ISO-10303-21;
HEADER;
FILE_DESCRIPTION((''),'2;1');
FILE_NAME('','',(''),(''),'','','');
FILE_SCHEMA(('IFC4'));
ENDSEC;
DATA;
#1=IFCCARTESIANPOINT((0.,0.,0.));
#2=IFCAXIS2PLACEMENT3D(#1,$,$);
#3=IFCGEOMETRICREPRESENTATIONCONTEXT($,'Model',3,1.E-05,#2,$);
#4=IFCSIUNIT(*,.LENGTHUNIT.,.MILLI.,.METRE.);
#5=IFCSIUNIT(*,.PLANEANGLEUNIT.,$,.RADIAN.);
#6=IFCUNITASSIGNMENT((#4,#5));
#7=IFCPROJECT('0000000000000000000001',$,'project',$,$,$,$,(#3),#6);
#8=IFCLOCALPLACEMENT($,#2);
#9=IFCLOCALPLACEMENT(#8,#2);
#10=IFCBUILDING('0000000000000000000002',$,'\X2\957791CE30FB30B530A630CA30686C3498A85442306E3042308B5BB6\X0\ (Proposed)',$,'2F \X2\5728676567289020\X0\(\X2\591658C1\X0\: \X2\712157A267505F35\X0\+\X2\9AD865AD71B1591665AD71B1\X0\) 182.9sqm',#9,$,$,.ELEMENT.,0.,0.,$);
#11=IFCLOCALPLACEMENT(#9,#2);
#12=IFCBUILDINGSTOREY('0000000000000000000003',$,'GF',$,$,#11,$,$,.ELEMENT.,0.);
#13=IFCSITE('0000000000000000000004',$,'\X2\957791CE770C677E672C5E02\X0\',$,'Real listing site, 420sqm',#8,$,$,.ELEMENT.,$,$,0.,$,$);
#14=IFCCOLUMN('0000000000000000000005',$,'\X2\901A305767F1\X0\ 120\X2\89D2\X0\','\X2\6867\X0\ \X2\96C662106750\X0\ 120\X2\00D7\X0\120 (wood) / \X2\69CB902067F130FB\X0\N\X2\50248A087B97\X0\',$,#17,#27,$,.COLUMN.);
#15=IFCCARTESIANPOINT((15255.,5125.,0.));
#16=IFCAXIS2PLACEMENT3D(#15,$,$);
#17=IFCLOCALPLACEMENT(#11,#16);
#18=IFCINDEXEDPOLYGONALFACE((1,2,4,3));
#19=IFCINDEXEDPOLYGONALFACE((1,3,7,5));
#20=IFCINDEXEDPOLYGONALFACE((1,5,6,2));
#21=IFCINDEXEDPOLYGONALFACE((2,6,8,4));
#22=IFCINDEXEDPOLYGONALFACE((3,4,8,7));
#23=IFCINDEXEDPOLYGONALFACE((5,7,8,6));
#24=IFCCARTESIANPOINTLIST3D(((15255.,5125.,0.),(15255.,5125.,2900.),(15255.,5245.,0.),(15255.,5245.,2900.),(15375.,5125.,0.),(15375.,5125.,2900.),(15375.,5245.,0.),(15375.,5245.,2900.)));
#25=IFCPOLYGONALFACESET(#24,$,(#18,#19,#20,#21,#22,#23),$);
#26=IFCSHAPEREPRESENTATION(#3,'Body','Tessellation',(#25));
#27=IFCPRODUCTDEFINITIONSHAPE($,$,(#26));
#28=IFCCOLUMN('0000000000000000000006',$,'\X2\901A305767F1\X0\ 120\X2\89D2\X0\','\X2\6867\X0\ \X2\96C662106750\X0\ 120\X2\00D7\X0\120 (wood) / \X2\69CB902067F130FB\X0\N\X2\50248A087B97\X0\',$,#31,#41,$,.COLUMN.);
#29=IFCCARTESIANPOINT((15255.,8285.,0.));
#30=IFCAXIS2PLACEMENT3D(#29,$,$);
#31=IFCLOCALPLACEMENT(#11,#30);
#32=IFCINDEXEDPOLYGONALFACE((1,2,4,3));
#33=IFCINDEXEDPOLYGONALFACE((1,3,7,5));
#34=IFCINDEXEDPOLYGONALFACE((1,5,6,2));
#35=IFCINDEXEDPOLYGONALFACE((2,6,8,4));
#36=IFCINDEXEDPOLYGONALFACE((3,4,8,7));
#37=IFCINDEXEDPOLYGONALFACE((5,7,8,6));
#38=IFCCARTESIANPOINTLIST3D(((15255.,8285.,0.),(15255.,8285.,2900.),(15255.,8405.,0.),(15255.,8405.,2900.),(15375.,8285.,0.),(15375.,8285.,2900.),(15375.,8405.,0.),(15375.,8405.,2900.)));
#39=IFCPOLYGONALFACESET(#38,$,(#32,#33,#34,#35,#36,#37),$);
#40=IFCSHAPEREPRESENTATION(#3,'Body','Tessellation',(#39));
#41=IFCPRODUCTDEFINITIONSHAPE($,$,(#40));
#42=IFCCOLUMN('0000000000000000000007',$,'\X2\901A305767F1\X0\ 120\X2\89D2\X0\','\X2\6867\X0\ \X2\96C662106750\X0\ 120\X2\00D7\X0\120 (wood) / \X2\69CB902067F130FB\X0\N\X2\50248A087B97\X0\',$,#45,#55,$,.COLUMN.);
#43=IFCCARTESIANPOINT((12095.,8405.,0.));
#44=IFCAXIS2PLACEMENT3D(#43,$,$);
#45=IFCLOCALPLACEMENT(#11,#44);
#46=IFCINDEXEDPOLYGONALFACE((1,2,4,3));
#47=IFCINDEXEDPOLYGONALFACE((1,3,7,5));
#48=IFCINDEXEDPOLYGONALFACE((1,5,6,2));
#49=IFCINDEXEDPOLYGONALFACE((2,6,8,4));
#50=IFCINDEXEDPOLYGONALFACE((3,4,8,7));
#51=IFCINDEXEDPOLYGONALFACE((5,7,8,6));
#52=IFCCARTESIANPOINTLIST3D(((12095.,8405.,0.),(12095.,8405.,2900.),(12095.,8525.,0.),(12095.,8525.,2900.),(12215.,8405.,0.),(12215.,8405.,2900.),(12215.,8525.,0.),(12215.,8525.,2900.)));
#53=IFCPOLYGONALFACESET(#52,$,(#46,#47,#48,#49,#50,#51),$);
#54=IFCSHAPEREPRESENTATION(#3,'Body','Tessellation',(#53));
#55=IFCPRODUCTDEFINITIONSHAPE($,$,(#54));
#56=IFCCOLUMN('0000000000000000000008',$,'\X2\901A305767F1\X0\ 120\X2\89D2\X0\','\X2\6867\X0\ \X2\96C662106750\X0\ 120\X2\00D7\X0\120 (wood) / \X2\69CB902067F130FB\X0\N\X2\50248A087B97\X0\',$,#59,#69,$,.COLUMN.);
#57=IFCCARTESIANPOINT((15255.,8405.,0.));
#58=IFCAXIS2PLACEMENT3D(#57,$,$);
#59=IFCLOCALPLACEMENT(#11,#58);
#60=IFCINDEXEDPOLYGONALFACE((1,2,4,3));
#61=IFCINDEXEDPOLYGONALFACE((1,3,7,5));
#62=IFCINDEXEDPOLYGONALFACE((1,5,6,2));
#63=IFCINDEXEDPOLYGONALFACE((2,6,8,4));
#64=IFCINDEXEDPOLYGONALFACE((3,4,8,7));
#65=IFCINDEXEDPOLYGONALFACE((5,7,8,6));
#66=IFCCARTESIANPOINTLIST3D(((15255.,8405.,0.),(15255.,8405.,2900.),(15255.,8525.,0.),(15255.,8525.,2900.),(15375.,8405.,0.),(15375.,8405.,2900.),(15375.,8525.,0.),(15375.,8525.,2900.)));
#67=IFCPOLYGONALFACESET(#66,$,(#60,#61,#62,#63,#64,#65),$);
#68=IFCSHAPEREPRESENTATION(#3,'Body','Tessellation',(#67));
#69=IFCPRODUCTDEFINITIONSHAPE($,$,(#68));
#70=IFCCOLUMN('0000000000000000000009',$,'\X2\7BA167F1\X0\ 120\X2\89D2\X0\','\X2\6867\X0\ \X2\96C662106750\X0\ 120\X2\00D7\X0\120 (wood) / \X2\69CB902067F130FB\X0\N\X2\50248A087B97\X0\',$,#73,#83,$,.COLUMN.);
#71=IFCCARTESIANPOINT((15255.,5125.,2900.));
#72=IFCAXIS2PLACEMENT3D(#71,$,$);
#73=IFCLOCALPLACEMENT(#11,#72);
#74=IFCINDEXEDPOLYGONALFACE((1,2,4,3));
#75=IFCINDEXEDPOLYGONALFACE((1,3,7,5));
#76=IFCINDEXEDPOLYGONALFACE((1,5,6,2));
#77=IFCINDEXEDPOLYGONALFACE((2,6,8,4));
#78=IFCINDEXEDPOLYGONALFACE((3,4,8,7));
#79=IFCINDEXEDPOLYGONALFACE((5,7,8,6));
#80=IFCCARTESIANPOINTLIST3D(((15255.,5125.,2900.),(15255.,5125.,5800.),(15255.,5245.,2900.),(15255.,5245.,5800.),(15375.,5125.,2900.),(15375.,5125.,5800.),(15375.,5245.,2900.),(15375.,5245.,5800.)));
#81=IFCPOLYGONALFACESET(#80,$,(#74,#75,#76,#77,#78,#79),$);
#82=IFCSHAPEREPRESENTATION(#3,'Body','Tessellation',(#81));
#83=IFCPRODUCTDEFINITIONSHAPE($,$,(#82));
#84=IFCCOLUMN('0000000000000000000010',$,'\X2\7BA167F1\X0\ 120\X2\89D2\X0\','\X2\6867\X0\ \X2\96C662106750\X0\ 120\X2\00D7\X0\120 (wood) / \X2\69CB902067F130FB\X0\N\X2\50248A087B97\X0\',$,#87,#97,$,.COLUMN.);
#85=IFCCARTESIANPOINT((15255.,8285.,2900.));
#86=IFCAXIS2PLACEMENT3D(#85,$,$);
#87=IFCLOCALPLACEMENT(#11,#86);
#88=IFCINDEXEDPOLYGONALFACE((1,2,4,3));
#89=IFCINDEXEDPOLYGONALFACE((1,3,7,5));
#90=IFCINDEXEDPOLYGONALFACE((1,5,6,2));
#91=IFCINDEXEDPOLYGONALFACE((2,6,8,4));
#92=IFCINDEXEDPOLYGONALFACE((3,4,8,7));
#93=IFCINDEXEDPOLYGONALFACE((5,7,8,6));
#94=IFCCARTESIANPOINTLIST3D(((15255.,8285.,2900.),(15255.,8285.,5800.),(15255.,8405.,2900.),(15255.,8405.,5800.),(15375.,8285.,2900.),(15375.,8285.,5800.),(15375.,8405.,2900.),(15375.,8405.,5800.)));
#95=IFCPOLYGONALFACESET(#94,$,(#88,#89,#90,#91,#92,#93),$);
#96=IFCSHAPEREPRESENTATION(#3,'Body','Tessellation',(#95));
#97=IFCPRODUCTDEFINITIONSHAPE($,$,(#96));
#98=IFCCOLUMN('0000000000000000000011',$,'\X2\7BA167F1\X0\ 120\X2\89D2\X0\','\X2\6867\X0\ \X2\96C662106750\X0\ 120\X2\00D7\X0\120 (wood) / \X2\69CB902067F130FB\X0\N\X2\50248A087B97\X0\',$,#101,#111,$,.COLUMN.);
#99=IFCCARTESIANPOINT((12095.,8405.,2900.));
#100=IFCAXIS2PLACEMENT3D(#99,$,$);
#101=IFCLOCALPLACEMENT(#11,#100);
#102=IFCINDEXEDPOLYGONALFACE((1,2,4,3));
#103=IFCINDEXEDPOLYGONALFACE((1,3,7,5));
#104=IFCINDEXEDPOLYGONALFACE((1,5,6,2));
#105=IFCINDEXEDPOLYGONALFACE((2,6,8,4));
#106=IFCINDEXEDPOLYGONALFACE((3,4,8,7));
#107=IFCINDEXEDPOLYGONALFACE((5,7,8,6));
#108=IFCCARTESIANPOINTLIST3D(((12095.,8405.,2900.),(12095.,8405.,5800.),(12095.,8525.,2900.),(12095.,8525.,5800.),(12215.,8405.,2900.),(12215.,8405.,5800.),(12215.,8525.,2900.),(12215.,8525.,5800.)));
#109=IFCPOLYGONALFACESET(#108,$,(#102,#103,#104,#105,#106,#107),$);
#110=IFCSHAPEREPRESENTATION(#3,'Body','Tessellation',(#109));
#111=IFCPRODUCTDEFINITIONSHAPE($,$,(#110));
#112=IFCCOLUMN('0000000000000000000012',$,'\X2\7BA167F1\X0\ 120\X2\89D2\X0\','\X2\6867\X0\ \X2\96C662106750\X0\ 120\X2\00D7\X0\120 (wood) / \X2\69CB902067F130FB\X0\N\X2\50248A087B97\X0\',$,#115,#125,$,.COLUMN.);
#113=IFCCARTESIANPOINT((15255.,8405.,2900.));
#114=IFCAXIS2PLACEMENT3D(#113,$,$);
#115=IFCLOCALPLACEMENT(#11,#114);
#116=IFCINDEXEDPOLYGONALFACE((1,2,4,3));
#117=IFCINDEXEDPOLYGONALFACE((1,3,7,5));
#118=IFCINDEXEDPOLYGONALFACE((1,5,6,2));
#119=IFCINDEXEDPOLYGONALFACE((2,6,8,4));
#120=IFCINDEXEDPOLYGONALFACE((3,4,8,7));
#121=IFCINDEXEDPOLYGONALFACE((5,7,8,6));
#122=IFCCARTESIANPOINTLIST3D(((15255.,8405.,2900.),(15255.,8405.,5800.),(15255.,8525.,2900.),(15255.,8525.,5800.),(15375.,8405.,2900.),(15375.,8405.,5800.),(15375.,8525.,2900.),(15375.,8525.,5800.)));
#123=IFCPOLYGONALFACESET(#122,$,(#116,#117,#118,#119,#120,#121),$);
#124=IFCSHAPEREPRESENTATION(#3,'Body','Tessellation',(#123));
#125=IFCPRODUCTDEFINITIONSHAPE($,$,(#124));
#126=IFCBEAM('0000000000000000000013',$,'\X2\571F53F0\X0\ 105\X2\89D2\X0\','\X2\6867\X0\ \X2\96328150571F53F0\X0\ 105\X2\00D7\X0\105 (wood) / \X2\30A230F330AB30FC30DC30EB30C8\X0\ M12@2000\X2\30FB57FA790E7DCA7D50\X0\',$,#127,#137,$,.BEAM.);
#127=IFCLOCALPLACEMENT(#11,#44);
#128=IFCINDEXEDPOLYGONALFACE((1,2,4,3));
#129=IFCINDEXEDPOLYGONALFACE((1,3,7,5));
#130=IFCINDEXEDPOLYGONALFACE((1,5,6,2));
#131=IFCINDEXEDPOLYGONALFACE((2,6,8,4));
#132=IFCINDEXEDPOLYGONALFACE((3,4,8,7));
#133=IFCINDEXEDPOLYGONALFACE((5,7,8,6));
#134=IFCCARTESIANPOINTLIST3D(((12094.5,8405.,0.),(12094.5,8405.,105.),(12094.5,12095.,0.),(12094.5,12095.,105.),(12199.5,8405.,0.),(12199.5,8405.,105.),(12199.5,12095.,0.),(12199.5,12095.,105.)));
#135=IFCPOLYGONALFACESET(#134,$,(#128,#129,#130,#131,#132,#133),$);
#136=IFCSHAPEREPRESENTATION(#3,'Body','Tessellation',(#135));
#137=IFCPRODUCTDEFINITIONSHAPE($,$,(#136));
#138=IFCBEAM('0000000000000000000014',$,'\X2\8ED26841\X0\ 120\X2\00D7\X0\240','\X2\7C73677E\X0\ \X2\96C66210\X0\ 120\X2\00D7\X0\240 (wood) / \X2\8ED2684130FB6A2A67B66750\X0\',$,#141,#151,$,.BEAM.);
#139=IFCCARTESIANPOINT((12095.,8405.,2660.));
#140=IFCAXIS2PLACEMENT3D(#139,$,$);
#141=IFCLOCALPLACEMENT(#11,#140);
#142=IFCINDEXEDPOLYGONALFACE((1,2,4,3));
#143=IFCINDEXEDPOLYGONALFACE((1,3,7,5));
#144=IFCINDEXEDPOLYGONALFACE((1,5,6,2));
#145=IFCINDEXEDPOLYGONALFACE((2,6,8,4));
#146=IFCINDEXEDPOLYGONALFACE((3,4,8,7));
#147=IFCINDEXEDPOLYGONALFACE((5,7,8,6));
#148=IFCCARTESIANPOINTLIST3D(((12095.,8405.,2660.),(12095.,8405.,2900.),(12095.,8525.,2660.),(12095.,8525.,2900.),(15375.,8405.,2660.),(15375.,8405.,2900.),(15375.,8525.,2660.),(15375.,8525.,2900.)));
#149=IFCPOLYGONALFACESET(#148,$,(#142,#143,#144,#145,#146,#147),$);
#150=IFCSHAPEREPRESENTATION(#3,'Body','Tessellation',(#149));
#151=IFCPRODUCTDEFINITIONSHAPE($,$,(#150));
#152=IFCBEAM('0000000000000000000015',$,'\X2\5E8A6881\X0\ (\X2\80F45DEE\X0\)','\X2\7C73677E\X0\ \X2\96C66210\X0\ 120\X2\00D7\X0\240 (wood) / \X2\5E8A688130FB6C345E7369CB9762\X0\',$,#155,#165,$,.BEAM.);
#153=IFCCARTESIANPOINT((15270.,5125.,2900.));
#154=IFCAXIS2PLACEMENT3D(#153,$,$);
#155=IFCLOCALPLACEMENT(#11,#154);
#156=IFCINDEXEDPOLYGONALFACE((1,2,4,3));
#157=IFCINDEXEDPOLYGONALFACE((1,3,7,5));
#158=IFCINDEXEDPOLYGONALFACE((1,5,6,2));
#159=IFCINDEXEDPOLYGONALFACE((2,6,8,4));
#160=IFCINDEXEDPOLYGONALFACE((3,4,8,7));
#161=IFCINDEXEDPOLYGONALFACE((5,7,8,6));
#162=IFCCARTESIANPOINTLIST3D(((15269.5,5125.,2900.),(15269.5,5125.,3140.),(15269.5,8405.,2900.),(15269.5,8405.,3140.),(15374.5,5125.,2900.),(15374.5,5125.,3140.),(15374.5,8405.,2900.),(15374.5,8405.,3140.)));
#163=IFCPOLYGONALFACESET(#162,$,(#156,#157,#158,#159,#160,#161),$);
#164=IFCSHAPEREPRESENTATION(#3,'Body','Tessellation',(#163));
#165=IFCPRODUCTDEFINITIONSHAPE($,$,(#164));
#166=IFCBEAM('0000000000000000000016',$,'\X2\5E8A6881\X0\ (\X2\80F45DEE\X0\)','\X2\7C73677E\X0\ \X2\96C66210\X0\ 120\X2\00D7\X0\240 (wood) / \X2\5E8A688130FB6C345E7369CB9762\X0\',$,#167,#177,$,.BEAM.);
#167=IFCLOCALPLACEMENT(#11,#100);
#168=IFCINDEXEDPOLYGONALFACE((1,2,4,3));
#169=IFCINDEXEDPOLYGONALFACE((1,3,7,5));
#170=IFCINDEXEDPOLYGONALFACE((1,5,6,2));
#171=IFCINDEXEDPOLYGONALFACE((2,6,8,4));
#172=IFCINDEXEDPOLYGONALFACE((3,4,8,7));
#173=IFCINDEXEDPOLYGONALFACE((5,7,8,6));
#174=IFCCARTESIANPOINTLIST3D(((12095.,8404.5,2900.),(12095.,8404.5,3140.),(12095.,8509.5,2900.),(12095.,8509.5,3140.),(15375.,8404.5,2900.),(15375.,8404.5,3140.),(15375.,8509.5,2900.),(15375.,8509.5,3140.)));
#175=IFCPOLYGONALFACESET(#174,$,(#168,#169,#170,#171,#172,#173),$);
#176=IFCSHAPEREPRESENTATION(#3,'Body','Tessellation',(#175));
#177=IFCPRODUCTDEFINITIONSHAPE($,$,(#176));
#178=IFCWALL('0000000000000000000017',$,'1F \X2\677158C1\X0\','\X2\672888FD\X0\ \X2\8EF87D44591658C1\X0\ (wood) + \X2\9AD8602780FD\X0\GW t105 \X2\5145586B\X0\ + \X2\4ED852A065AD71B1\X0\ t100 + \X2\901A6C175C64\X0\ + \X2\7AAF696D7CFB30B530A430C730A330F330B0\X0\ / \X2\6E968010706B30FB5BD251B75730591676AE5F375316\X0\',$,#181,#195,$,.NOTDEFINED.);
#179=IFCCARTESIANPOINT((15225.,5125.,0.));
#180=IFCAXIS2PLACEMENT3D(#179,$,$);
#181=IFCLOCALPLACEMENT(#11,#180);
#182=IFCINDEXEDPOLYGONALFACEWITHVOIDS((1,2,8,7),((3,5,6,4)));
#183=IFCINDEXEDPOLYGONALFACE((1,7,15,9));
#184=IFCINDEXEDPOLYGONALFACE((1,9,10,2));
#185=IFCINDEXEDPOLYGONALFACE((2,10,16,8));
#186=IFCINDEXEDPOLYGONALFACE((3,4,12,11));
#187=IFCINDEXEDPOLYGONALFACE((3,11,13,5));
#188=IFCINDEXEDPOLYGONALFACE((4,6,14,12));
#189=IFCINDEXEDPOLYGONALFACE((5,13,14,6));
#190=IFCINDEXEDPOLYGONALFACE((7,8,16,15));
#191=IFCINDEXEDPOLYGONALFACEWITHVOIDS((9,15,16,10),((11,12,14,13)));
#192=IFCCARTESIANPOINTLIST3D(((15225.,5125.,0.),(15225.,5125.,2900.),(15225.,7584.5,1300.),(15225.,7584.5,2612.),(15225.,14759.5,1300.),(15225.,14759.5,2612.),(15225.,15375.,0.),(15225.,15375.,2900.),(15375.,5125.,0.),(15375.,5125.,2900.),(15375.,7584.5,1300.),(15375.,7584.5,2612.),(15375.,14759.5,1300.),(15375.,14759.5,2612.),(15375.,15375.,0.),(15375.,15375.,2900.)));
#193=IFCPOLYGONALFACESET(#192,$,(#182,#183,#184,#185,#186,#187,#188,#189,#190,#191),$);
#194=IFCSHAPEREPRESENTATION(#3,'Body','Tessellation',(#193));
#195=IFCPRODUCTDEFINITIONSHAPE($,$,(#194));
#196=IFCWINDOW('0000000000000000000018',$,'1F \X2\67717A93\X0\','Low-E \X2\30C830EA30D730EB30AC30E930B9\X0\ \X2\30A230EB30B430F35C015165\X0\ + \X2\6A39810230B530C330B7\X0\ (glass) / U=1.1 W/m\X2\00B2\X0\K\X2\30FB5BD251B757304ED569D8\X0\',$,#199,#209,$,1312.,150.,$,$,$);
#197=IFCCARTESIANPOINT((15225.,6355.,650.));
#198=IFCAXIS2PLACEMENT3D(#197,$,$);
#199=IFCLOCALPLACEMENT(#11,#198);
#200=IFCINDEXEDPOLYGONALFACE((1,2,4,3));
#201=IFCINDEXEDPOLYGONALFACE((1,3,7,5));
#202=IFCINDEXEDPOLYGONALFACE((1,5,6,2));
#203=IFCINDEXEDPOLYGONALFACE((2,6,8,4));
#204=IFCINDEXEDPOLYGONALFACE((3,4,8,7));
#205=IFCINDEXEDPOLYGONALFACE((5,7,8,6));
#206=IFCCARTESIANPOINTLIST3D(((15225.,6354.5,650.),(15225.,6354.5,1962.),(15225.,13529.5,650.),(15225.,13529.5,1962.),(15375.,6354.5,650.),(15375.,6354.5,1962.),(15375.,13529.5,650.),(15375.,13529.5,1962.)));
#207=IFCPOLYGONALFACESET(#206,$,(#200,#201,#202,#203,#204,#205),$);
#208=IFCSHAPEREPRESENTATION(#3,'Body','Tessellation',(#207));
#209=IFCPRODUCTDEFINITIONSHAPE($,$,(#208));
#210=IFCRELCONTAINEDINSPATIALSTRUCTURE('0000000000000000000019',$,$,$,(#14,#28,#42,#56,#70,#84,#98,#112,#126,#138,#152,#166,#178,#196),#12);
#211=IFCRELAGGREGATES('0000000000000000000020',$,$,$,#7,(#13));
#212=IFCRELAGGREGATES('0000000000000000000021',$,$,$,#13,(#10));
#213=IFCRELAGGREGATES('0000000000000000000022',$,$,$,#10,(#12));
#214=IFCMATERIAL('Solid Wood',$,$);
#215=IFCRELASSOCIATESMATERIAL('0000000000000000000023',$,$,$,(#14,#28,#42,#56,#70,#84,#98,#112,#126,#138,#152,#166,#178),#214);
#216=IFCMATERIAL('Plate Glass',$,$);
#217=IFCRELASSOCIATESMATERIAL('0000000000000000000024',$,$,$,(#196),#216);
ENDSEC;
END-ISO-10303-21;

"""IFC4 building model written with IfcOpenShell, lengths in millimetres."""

from ifc_helpers import new_model, si_unit, frame, frame_2d, origin, place, context, project, spatial, rectangle, extrude, material, element, fill, save


model = new_model("IFC4")

# Units and contexts
model_context = context("Model", 3, precision=1e-05, world=origin())
ifc_project = project(units=[si_unit("LENGTHUNIT", "METRE", prefix="MILLI"), si_unit("PLANEANGLEUNIT", "RADIAN")], contexts=[model_context])

# Site, building, storey
site_placement = place(None, origin())
site = spatial("IfcSite", under=ifc_project, at=site_placement, Name="長野県松本市", ObjectType="Real listing site, 420sqm", CompositionType="ELEMENT", RefElevation=0.0)
building_placement = place(site_placement, origin())
building = spatial("IfcBuilding", under=site, at=building_placement, Name="長野・サウナと水風呂のある家 (Proposed)", ObjectType="2F 在来木造(外壁: 無垢材張+高断熱外断熱) 182.9sqm", CompositionType="ELEMENT", ElevationOfRefHeight=0.0, ElevationOfTerrain=0.0)
storey_placement = place(building_placement, origin())
storey = spatial("IfcBuildingStorey", under=building, at=storey_placement, Name="GF", CompositionType="ELEMENT", Elevation=0.0)

# Columns
ifc_material_1 = material(Name="Solid Wood")
column_1_placement = place(storey_placement, frame((15255.0, 5125.0, 0.0)))
element("IfcColumn", 1, at=column_1_placement, inside=storey, material=ifc_material_1, Name="通し柱 120角", Description="桧 集成材 120×120 (wood) / 構造柱・N値計算", PredefinedType="COLUMN", context=model_context, shape_type="SweptSolid", body=[
    extrude(rectangle(XDim=120.0, YDim=120.0, at=frame_2d((60.0, 60.0))), frame((15255.0, 5125.0, 0.0)), (0.0, 0.0, 1.0), 2900.0),
])
column_2_placement = place(storey_placement, frame((15255.0, 8285.0, 0.0)))
element("IfcColumn", 2, at=column_2_placement, inside=storey, material=ifc_material_1, Name="通し柱 120角", Description="桧 集成材 120×120 (wood) / 構造柱・N値計算", PredefinedType="COLUMN", context=model_context, shape_type="SweptSolid", body=[
    extrude(rectangle(XDim=120.0, YDim=120.0, at=frame_2d((60.0, 60.0))), frame((15255.0, 8285.0, 0.0)), (0.0, 0.0, 1.0), 2900.0),
])
column_3_placement = place(storey_placement, frame((12095.0, 8405.0, 0.0)))
element("IfcColumn", 3, at=column_3_placement, inside=storey, material=ifc_material_1, Name="通し柱 120角", Description="桧 集成材 120×120 (wood) / 構造柱・N値計算", PredefinedType="COLUMN", context=model_context, shape_type="SweptSolid", body=[
    extrude(rectangle(XDim=120.0, YDim=120.0, at=frame_2d((60.0, 60.0))), frame((12095.0, 8405.0, 0.0)), (0.0, 0.0, 1.0), 2900.0),
])
column_4_placement = place(storey_placement, frame((15255.0, 8405.0, 0.0)))
element("IfcColumn", 4, at=column_4_placement, inside=storey, material=ifc_material_1, Name="通し柱 120角", Description="桧 集成材 120×120 (wood) / 構造柱・N値計算", PredefinedType="COLUMN", context=model_context, shape_type="SweptSolid", body=[
    extrude(rectangle(XDim=120.0, YDim=120.0, at=frame_2d((60.0, 60.0))), frame((15255.0, 8405.0, 0.0)), (0.0, 0.0, 1.0), 2900.0),
])
column_5_placement = place(storey_placement, frame((15255.0, 5125.0, 2900.0)))
element("IfcColumn", 5, at=column_5_placement, inside=storey, material=ifc_material_1, Name="管柱 120角", Description="桧 集成材 120×120 (wood) / 構造柱・N値計算", PredefinedType="COLUMN", context=model_context, shape_type="SweptSolid", body=[
    extrude(rectangle(XDim=120.0, YDim=120.0, at=frame_2d((60.0, 60.0))), frame((15255.0, 5125.0, 2900.0)), (0.0, 0.0, 1.0), 2900.0),
])
column_6_placement = place(storey_placement, frame((15255.0, 8285.0, 2900.0)))
element("IfcColumn", 6, at=column_6_placement, inside=storey, material=ifc_material_1, Name="管柱 120角", Description="桧 集成材 120×120 (wood) / 構造柱・N値計算", PredefinedType="COLUMN", context=model_context, shape_type="SweptSolid", body=[
    extrude(rectangle(XDim=120.0, YDim=120.0, at=frame_2d((60.0, 60.0))), frame((15255.0, 8285.0, 2900.0)), (0.0, 0.0, 1.0), 2900.0),
])
column_7_placement = place(storey_placement, frame((12095.0, 8405.0, 2900.0)))
element("IfcColumn", 7, at=column_7_placement, inside=storey, material=ifc_material_1, Name="管柱 120角", Description="桧 集成材 120×120 (wood) / 構造柱・N値計算", PredefinedType="COLUMN", context=model_context, shape_type="SweptSolid", body=[
    extrude(rectangle(XDim=120.0, YDim=120.0, at=frame_2d((60.0, 60.0))), frame((12095.0, 8405.0, 2900.0)), (0.0, 0.0, 1.0), 2900.0),
])
column_8_placement = place(storey_placement, frame((15255.0, 8405.0, 2900.0)))
element("IfcColumn", 8, at=column_8_placement, inside=storey, material=ifc_material_1, Name="管柱 120角", Description="桧 集成材 120×120 (wood) / 構造柱・N値計算", PredefinedType="COLUMN", context=model_context, shape_type="SweptSolid", body=[
    extrude(rectangle(XDim=120.0, YDim=120.0, at=frame_2d((60.0, 60.0))), frame((15255.0, 8405.0, 2900.0)), (0.0, 0.0, 1.0), 2900.0),
])

# Beams
beam_1_placement = place(storey_placement, frame((12095.0, 8405.0, 0.0)))
element("IfcBeam", 9, at=beam_1_placement, inside=storey, material=ifc_material_1, Name="土台 105角", Description="桧 防腐土台 105×105 (wood) / アンカーボルト M12@2000・基礎緊結", PredefinedType="BEAM", context=model_context, shape_type="SweptSolid", body=[
    extrude(rectangle(XDim=105.0, YDim=3690.0, at=frame_2d((52.0, 1845.0))), frame((12095.0, 8405.0, 0.0)), (0.0, 0.0, 1.0), 105.0),
])
beam_2_placement = place(storey_placement, frame((12095.0, 8405.0, 2660.0)))
element("IfcBeam", 10, at=beam_2_placement, inside=storey, material=ifc_material_1, Name="軒桁 120×240", Description="米松 集成 120×240 (wood) / 軒桁・横架材", PredefinedType="BEAM", context=model_context, shape_type="SweptSolid", body=[
    extrude(rectangle(XDim=3280.0, YDim=120.0, at=frame_2d((1640.0, 60.0))), frame((12095.0, 8405.0, 2660.0)), (0.0, 0.0, 1.0), 240.0),
])
beam_3_placement = place(storey_placement, frame((15270.0, 5125.0, 2900.0)))
element("IfcBeam", 11, at=beam_3_placement, inside=storey, material=ifc_material_1, Name="床梁 (胴差)", Description="米松 集成 120×240 (wood) / 床梁・水平構面", PredefinedType="BEAM", context=model_context, shape_type="SweptSolid", body=[
    extrude(rectangle(XDim=105.0, YDim=3280.0, at=frame_2d((52.0, 1640.0))), frame((15270.0, 5125.0, 2900.0)), (0.0, 0.0, 1.0), 240.0),
])
beam_4_placement = place(storey_placement, frame((12095.0, 8405.0, 2900.0)))
element("IfcBeam", 12, at=beam_4_placement, inside=storey, material=ifc_material_1, Name="床梁 (胴差)", Description="米松 集成 120×240 (wood) / 床梁・水平構面", PredefinedType="BEAM", context=model_context, shape_type="SweptSolid", body=[
    extrude(rectangle(XDim=3280.0, YDim=105.0, at=frame_2d((1640.0, 52.0))), frame((12095.0, 8405.0, 2900.0)), (0.0, 0.0, 1.0), 240.0),
])

# Wall, opening, window
wall_1_placement = place(storey_placement, frame((15225.0, 5125.0, 0.0)))
wall_1 = element("IfcWall", 13, at=wall_1_placement, inside=storey, material=ifc_material_1, Name="1F 東壁", Description="木製 軸組外壁 (wood) + 高性能GW t105 充填 + 付加断熱 t100 + 通気層 + 窯業系サイディング / 準耐火・寒冷地外皮強化", PredefinedType="NOTDEFINED", context=model_context, shape_type="SweptSolid", body=[
    extrude(rectangle(XDim=150.0, YDim=10250.0, at=frame_2d((75.0, 5125.0))), frame((15225.0, 5125.0, 0.0)), (0.0, 0.0, 1.0), 2900.0),
])
opening_1_placement = place(storey_placement, frame((15225.0, 6355.0, 650.0)))
opening_1 = element("IfcOpeningElement", 14, at=opening_1_placement, cuts=wall_1, PredefinedType="NOTDEFINED", context=model_context, shape_type="SweptSolid", body=[
    extrude(rectangle(XDim=150.0, YDim=7175.0, at=frame_2d((75.0, 3587.0))), frame((15225.0, 6355.0, 650.0)), (0.0, 0.0, 1.0), 1312.0),
])
ifc_material_2 = material(Name="Plate Glass")
window_1_placement = place(storey_placement, frame((15225.0, 6355.0, 650.0)))
window_1 = element("IfcWindow", 15, at=window_1_placement, inside=storey, material=ifc_material_2, Name="1F 東窓", Description="Low-E トリプルガラス アルゴン封入 + 樹脂サッシ (glass) / U=1.1 W/m²K・寒冷地仕様", OverallHeight=1312.0, OverallWidth=150.0, context=model_context, shape_type="SweptSolid", body=[
    extrude(rectangle(XDim=150.0, YDim=7175.0, at=frame_2d((75.0, 3587.0))), frame((15225.0, 6355.0, 650.0)), (0.0, 0.0, 1.0), 1312.0),
])
fill(opening_1, window_1)

save(model, "model.ifc")
